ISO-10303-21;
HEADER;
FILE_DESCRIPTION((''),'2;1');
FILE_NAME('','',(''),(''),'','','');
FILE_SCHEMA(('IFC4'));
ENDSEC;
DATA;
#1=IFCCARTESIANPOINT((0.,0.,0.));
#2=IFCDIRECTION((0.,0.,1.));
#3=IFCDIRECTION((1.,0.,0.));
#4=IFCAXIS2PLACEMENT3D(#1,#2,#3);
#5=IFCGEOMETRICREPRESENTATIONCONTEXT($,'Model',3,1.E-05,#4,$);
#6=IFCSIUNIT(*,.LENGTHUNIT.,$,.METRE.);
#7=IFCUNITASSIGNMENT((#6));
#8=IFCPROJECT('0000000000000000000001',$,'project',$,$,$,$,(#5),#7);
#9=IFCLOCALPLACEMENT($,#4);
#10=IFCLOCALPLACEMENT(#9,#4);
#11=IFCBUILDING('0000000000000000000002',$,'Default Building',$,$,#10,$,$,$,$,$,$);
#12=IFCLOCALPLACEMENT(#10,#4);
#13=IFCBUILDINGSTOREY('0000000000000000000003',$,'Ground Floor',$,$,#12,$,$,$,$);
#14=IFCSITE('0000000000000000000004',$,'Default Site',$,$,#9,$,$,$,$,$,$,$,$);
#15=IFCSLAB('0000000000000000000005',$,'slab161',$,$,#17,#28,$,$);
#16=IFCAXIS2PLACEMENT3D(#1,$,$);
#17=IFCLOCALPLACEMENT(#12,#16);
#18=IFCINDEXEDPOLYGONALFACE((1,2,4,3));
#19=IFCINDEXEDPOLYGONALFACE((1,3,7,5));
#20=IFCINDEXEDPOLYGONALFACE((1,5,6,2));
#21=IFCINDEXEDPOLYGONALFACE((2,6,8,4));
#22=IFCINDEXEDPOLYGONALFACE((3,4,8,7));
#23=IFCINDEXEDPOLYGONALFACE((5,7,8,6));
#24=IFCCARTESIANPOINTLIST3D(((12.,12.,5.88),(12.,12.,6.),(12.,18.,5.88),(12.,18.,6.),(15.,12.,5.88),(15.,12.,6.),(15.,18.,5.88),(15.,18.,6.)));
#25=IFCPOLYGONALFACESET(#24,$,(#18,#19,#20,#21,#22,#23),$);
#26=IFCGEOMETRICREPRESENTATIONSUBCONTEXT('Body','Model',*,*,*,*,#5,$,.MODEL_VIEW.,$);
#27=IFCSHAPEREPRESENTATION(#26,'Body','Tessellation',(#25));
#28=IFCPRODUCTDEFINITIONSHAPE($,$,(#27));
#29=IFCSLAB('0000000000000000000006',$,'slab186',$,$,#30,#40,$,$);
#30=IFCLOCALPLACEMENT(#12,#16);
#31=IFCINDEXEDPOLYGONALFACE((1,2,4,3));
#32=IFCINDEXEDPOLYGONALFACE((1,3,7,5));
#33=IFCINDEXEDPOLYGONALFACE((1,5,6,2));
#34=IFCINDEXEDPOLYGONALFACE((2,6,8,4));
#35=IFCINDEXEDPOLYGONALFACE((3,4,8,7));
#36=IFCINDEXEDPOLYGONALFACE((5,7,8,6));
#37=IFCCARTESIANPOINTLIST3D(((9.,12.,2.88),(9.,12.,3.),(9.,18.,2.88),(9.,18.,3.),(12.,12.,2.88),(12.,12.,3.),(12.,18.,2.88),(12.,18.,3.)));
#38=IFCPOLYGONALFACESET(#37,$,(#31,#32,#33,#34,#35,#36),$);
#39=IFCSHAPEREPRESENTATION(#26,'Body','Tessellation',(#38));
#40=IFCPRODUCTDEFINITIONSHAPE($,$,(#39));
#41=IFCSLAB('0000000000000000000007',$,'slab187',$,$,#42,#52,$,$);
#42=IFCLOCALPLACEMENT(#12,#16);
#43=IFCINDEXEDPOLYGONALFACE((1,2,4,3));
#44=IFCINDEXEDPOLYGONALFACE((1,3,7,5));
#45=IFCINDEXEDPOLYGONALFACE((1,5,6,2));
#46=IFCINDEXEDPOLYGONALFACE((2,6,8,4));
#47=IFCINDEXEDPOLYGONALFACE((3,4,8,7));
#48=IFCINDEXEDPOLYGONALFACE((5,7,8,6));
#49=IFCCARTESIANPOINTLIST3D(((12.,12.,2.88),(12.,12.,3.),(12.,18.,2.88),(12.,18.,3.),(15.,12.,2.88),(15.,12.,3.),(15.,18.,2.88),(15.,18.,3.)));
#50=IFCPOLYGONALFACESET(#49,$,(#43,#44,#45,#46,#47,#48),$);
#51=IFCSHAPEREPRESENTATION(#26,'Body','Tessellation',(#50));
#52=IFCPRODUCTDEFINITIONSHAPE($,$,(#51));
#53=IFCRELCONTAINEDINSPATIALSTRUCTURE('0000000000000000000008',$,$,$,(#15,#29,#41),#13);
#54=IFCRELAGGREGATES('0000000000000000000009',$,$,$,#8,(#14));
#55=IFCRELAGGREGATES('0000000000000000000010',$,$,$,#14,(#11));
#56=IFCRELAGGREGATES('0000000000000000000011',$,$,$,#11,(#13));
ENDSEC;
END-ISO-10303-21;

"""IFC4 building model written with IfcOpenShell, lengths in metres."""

from ifc_helpers import new_model, si_unit, frame, origin_with_axes, place, context, subcontext, project, spatial, indexed_curve, outline, extrude, element, save


model = new_model("IFC4")

# Units and contexts
model_context = context("Model", 3, precision=1e-05, world=origin_with_axes())
body_context = subcontext(model_context, "Body", "Model", "MODEL_VIEW")
ifc_project = project(units=[si_unit("LENGTHUNIT", "METRE")], contexts=[model_context])

# Site, building, storey
site_placement = place(None, origin_with_axes())
site = spatial("IfcSite", under=ifc_project, at=site_placement, Name="Default Site")
building_placement = place(site_placement, origin_with_axes())
building = spatial("IfcBuilding", under=site, at=building_placement, Name="Default Building")
storey_placement = place(building_placement, origin_with_axes())
storey = spatial("IfcBuildingStorey", under=building, at=storey_placement, Name="Ground Floor")

# Slabs
for number, where, z_axis, x_axis, name in (
    (1, (12.0, 12.0, 5.88), (0.0, 0.0, 1.0), (1.0, 0.0, 0.0), "slab161"),
    (2, (9.0, 12.0, 2.88), (0.0, 0.0, 1.0), (1.0, 0.0, 0.0), "slab186"),
    (3, (12.0, 12.0, 2.88), (0.0, 0.0, 1.0), (1.0, 0.0, 0.0), "slab187"),
):
    element("IfcSlab", number, at=place(storey_placement, frame(where, z_axis=z_axis, x_axis=x_axis)), inside=storey, Name=name, context=body_context, shape_type="SweptSolid", body=[
        extrude(outline(indexed_curve([(0.0, 0.0), (0.0, 6.0), (3.0, 6.0), (3.0, 0.0), (0.0, 0.0)], self_intersect=False)), origin_with_axes(), (0.0, 0.0, 1.0), 0.12),
    ])

save(model, "model.ifc")
